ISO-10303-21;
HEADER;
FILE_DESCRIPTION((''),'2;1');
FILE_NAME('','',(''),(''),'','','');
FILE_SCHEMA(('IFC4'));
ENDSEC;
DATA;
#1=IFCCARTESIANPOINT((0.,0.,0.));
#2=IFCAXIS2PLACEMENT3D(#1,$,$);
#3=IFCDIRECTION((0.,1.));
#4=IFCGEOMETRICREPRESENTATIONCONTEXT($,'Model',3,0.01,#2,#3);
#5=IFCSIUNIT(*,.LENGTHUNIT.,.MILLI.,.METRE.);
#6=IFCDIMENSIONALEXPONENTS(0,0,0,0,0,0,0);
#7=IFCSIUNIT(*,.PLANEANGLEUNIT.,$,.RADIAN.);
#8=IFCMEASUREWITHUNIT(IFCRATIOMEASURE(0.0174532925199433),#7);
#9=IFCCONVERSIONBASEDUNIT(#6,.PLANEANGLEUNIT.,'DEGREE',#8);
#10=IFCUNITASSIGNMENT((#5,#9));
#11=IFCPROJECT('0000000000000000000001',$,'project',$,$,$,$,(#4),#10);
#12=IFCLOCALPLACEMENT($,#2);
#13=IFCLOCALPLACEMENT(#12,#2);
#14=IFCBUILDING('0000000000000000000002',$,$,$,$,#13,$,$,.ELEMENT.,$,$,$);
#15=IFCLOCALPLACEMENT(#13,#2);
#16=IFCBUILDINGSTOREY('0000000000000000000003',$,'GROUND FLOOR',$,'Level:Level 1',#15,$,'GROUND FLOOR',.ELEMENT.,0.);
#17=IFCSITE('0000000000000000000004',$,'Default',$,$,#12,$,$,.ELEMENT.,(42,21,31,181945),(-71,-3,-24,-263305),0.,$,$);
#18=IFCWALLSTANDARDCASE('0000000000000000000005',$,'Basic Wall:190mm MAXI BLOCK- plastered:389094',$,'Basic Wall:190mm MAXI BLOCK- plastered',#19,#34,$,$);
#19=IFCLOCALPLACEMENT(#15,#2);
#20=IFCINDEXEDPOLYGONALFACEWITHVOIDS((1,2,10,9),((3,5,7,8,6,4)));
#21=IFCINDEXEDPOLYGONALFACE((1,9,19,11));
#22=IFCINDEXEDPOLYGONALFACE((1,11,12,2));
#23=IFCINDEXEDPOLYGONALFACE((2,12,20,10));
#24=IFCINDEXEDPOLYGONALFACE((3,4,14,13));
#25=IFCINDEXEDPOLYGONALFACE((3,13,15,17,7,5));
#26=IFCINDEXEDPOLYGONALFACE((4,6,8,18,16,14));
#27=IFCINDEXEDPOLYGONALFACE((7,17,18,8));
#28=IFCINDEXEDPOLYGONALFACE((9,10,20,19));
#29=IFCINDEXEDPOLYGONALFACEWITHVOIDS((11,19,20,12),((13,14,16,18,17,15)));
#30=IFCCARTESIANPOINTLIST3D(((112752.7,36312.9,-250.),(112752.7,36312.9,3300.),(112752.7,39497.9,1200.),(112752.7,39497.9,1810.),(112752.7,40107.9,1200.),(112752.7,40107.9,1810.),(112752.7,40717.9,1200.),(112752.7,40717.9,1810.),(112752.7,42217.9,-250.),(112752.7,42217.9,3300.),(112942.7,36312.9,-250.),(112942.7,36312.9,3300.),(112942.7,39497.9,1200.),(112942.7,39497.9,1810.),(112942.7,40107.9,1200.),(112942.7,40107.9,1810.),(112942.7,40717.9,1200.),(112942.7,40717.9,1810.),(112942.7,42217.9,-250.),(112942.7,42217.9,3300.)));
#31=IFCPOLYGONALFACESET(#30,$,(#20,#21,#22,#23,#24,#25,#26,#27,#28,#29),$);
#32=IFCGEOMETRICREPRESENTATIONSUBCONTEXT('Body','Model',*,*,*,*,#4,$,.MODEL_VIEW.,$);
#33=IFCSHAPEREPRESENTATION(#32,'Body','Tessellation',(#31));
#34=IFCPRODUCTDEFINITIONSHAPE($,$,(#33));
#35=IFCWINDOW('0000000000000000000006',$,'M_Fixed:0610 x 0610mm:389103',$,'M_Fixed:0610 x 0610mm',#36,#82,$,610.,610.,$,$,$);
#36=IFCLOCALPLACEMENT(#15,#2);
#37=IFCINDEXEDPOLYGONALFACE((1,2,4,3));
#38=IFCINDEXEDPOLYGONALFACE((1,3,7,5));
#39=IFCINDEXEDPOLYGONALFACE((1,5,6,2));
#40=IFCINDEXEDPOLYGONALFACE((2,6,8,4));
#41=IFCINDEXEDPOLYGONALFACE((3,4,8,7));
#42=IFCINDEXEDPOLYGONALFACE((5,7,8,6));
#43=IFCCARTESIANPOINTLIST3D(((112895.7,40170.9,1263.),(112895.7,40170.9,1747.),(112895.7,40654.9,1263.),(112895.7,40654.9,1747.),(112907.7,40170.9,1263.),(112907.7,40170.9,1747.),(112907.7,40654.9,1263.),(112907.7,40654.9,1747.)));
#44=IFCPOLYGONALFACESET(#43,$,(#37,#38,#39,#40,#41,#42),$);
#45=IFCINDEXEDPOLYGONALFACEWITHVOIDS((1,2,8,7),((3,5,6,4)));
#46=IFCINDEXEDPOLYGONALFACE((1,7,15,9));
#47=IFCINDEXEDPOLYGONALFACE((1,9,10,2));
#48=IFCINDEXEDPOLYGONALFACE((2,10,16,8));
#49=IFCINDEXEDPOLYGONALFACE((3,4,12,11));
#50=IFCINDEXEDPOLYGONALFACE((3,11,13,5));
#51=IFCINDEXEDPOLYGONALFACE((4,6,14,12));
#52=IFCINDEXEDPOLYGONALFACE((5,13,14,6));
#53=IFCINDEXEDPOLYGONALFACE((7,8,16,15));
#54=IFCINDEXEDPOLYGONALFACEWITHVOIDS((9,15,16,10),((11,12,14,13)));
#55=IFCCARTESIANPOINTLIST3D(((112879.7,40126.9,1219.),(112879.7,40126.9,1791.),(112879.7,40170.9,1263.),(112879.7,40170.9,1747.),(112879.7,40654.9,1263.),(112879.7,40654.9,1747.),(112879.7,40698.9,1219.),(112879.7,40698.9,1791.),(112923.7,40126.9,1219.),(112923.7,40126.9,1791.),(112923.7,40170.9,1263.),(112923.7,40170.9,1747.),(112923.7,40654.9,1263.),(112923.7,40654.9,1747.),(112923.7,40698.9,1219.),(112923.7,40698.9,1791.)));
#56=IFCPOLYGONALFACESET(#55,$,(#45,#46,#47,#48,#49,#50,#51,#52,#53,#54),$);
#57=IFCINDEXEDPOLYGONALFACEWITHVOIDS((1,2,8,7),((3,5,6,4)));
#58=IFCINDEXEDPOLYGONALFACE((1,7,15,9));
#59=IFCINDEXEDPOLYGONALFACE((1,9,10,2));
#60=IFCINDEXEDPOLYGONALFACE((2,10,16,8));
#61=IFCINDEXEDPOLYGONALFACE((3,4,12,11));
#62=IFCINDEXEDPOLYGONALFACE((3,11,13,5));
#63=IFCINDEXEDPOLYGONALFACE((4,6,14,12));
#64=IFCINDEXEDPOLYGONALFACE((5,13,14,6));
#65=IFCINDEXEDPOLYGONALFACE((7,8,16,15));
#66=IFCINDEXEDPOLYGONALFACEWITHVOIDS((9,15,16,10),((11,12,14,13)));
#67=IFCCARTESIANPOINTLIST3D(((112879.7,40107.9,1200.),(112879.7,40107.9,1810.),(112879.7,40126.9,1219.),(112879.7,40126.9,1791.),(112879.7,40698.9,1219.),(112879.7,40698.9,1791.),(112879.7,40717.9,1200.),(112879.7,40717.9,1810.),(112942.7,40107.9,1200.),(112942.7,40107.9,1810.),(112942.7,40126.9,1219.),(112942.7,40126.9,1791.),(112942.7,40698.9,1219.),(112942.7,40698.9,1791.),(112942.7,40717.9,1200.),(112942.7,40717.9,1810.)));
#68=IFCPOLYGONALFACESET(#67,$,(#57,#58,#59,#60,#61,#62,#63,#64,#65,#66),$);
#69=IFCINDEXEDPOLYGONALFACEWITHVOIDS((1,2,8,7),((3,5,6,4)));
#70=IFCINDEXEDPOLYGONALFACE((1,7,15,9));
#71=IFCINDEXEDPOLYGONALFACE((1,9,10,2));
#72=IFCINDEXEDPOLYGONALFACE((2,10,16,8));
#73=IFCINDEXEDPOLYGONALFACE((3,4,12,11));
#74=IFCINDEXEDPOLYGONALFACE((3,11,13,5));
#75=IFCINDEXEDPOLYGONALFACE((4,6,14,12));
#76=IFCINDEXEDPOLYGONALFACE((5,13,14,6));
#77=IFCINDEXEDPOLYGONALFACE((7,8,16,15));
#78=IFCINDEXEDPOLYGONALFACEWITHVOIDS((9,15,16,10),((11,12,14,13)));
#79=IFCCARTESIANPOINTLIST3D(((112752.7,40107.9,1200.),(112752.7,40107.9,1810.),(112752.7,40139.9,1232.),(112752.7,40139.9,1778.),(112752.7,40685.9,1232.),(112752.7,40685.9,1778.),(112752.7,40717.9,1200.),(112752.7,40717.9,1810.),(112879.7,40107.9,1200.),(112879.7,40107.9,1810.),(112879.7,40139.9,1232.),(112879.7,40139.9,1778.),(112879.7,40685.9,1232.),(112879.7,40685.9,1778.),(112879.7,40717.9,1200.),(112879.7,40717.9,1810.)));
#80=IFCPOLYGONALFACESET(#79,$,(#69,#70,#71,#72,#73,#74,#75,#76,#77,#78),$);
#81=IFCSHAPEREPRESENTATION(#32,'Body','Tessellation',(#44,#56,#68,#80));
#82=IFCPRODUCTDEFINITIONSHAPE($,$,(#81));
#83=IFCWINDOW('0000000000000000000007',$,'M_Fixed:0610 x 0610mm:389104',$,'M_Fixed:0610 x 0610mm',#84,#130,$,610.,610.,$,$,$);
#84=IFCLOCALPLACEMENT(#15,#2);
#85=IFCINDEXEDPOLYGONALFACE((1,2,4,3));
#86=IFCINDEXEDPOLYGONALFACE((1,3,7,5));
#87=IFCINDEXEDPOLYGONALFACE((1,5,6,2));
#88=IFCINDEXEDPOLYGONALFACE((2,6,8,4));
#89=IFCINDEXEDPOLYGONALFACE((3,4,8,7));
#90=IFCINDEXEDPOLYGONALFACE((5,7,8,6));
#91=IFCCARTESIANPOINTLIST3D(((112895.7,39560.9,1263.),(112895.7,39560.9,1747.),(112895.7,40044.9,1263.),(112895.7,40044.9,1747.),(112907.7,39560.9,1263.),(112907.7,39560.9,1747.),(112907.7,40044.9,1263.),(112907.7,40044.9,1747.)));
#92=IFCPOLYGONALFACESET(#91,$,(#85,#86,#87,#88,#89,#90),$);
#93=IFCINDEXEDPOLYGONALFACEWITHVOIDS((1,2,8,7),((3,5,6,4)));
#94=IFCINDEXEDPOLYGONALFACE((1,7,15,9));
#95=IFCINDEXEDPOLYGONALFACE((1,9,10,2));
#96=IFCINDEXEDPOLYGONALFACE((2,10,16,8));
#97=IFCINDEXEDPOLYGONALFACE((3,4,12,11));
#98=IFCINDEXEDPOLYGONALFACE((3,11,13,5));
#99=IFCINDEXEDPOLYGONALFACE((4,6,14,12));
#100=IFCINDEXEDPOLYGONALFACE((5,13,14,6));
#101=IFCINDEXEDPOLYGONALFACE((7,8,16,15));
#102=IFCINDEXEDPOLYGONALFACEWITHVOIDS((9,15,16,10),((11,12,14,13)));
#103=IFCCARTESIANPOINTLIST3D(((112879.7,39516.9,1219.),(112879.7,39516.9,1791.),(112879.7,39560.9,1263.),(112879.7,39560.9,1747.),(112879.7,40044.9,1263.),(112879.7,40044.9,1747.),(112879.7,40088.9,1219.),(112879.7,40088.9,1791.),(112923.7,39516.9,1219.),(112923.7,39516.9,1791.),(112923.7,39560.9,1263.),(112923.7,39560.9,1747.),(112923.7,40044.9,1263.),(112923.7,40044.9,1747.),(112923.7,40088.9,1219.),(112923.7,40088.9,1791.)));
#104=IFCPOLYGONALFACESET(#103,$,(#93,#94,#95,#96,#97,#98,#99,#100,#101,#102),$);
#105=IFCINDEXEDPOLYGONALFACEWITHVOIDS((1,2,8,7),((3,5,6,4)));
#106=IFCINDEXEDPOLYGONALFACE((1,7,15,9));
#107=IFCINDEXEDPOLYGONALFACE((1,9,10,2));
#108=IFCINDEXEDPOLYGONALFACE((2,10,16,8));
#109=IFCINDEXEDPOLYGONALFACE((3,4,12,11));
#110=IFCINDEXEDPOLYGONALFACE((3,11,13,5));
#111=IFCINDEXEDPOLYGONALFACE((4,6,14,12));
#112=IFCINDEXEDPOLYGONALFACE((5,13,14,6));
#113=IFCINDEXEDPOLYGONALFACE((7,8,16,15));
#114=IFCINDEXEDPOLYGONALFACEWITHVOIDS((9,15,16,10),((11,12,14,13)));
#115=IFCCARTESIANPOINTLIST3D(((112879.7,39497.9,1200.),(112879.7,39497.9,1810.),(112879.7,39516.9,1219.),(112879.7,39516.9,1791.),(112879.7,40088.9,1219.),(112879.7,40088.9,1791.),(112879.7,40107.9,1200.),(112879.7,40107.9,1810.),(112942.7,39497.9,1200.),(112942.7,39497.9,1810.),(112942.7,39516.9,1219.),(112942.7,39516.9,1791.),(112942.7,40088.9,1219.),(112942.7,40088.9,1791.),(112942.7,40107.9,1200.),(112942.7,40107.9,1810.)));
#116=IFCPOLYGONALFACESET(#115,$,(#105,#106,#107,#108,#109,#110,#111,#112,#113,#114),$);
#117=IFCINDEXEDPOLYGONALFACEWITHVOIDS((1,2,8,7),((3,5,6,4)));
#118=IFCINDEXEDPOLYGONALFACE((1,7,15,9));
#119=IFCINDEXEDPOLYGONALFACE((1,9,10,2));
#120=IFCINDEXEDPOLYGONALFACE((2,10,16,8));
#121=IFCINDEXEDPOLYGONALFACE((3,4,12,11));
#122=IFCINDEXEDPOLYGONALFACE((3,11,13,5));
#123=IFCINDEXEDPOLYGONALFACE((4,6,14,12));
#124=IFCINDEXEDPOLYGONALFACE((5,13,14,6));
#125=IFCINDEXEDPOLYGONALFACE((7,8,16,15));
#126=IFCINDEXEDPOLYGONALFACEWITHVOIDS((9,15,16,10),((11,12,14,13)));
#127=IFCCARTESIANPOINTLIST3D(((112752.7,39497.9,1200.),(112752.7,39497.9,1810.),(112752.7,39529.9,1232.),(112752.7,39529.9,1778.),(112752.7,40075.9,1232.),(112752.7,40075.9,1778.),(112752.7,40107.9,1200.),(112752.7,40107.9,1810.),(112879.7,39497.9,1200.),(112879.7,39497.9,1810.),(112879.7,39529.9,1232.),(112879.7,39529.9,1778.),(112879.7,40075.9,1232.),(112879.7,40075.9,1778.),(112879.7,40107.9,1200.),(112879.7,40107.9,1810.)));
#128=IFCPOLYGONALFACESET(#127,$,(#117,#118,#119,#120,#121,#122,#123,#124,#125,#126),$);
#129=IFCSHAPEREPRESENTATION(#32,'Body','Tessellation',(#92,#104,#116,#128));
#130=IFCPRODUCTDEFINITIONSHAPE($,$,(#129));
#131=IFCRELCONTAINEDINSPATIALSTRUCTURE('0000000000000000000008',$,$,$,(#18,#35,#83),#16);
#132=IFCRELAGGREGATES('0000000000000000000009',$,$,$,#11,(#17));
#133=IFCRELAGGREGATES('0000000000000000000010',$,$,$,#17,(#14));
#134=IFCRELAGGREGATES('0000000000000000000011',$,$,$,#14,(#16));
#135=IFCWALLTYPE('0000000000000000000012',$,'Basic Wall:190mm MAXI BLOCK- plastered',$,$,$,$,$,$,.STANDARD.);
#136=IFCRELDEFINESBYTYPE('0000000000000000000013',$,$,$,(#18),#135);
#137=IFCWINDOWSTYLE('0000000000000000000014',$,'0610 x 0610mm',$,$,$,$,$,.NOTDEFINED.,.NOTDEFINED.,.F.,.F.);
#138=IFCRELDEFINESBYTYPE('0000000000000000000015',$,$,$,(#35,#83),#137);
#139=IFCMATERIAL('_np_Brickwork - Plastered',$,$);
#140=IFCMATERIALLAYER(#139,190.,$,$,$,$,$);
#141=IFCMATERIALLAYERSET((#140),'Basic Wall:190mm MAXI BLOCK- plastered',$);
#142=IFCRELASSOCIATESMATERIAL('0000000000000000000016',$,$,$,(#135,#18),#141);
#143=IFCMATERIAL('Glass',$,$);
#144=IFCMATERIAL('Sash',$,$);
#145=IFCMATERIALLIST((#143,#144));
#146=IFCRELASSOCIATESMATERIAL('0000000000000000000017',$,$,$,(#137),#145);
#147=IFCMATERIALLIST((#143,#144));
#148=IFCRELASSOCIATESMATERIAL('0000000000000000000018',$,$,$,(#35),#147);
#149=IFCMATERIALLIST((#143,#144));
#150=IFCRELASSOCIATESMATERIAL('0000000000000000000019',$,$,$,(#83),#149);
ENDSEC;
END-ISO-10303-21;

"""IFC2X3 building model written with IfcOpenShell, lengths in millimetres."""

from ifc_helpers import new_model, entity, si_unit, converted_unit, direction, frame, frame_2d, origin, place, context, subcontext, project, spatial, polyline, rectangle, outline, extrude, source, transform, mapped, material, material_list, layer, layer_set, layer_usage, type_object, type_shapes, element, fill, save


model = new_model("IFC2X3")

# Units and contexts
model_context = context("Model", 3, precision=0.01, world=origin(), true_north=direction((0.0, 1.0)))
body_context = subcontext(model_context, "Body", "Model", "MODEL_VIEW")
ifc_project = project(units=[si_unit("LENGTHUNIT", "METRE", prefix="MILLI"), converted_unit("PLANEANGLEUNIT", "DEGREE", entity("IfcRatioMeasure", 0.0174532925199433), si_unit("PLANEANGLEUNIT", "RADIAN"), dimensions=[0, 0, 0, 0, 0, 0, 0])], contexts=[model_context])

# Site, building, storey
site_placement = place(None, origin())
site = spatial("IfcSite", under=ifc_project, at=site_placement, Name="Default", CompositionType="ELEMENT", RefLatitude=(42, 21, 31, 181945), RefLongitude=(-71, -3, -24, -263305), RefElevation=0.0)
building_placement = place(site_placement, origin())
building = spatial("IfcBuilding", under=site, at=building_placement, CompositionType="ELEMENT")
storey_placement = place(building_placement, origin())
storey = spatial("IfcBuildingStorey", under=building, at=storey_placement, Name="GROUND FLOOR", ObjectType="Level:Level 1", LongName="GROUND FLOOR", CompositionType="ELEMENT", Elevation=0.0)

# Wall, openings, windows
ifc_material_1 = material(Name="_np_Brickwork - Plastered")
ifc_layer = layer(ifc_material_1, 190.0)
ifc_layer_set = layer_set([ifc_layer], Name="Basic Wall:190mm MAXI BLOCK- plastered")
ifc_layer_usage_1 = layer_usage(ifc_layer_set, "AXIS2", "NEGATIVE", 95.0)
wall_type = type_object("IfcWallType", Name="Basic Wall:190mm MAXI BLOCK- plastered", PredefinedType="STANDARD", material=ifc_layer_set)
wall_1_placement = place(storey_placement, frame((112847.7, 36312.9, -250.0), z_axis=(0.0, 0.0, 1.0), x_axis=(0.0, 1.0, 0.0)))
wall_1 = element("IfcWallStandardCase", 1, at=wall_1_placement, inside=storey, type_object=wall_type, material=ifc_layer_usage_1, Name="Basic Wall:190mm MAXI BLOCK- plastered:389094", ObjectType="Basic Wall:190mm MAXI BLOCK- plastered", context=body_context, shape_type="SweptSolid", body=[
    extrude(rectangle(XDim=5905.0, YDim=190.0, at=frame_2d((2952.5, 0.0), x_axis=(-1.0, 0.0))), origin(), (0.0, 0.0, 1.0), 3550.0),
])
opening_1_placement = place(wall_1_placement, frame((4405.0, 95.0, 1450.0)))
opening_1 = element("IfcOpeningElement", 2, at=opening_1_placement, cuts=wall_1, ObjectType="Opening", context=body_context, shape_type="SweptSolid", body=[
    extrude(rectangle(XDim=610.0, YDim=610.0, at=frame_2d((305.0, 305.0), x_axis=(1.0, 0.0))), frame((0.0, 0.0, 0.0), z_axis=(0.0, -1.0, 0.0), x_axis=(0.0, 0.0, 1.0)), (0.0, 0.0, 1.0), 190.0),
])
opening_2_placement = place(wall_1_placement, frame((3795.0, 95.0, 1450.0)))
opening_2 = element("IfcOpeningElement", 3, at=opening_2_placement, cuts=wall_1, ObjectType="Opening", context=body_context, shape_type="SweptSolid", body=[
    extrude(rectangle(XDim=610.0, YDim=610.0, at=frame_2d((305.0, 305.0), x_axis=(1.0, 0.0))), frame((0.0, 0.0, 0.0), z_axis=(0.0, -1.0, 0.0), x_axis=(0.0, 0.0, 1.0)), (0.0, 0.0, 1.0), 190.0),
])
ifc_material_2 = material(Name="Glass")
ifc_material_3 = material(Name="Sash")
ifc_material_list_1 = material_list([ifc_material_2, ifc_material_3])
ifc_material_list_2 = material_list([ifc_material_2, ifc_material_3])
window_style = type_object("IfcWindowStyle", Name="0610 x 0610mm", ConstructionType="NOTDEFINED", OperationType="NOTDEFINED", ParameterTakesPrecedence=False, Sizeable=False, material=ifc_material_list_2)
shared_shape_1 = source(origin(), body_context, "Body", "SweptSolid", [
    extrude(rectangle(XDim=12.0, YDim=484.0, at=frame_2d((0.0, 0.0), x_axis=(1.0, 0.0))), frame((305.0, 149.0, 63.0), z_axis=(0.0, 0.0, 1.0), x_axis=(0.0, -1.0, 0.0)), (0.0, 0.0, 1.0), 484.0),
    extrude(outline(polyline([(-286.0, -286.0), (286.0, -286.0), (286.0, 286.0), (-286.0, 286.0), (-286.0, -286.0)]), holes=[polyline([(-242.0, -242.0), (-242.0, 242.0), (242.0, 242.0), (242.0, -242.0), (-242.0, -242.0)])]), frame((305.0, 127.0, 305.0), z_axis=(0.0, 1.0, 0.0), x_axis=(1.0, 0.0, 0.0)), (0.0, 0.0, 1.0), 44.0),
    extrude(outline(polyline([(-305.0, -305.0), (305.0, -305.0), (305.0, 305.0), (-305.0, 305.0), (-305.0, -305.0)]), holes=[polyline([(-286.0, -286.0), (-286.0, 286.0), (286.0, 286.0), (286.0, -286.0), (-286.0, -286.0)])]), frame((305.0, 127.0, 305.0), z_axis=(0.0, 1.0, 0.0), x_axis=(1.0, 0.0, 0.0)), (0.0, 0.0, 1.0), 63.0),
    extrude(outline(polyline([(-305.0, -305.0), (305.0, -305.0), (305.0, 305.0), (-305.0, 305.0), (-305.0, -305.0)]), holes=[polyline([(-273.0, -273.0), (-273.0, 273.0), (273.0, 273.0), (273.0, -273.0), (-273.0, -273.0)])]), frame((305.0, 0.0, 305.0), z_axis=(0.0, 1.0, 0.0), x_axis=(1.0, 0.0, 0.0)), (0.0, 0.0, 1.0), 127.0),
])
type_shapes(window_style, [shared_shape_1])
window_1_placement = place(opening_1_placement, frame((0.0, 0.0, 0.0), z_axis=(0.0, 0.0, 1.0), x_axis=(-1.0, 0.0, 0.0)))
window_1 = element("IfcWindow", 4, at=window_1_placement, inside=storey, type_object=window_style, material=ifc_material_list_1, Name="M_Fixed:0610 x 0610mm:389103", ObjectType="M_Fixed:0610 x 0610mm", OverallHeight=610.0, OverallWidth=610.0, context=body_context, shape_type="MappedRepresentation", body=[
    mapped(shared_shape_1, transform((0.0, 0.0, 0.0), scale=1.0)),
])
fill(opening_1, window_1)
ifc_material_list_3 = material_list([ifc_material_2, ifc_material_3])
window_2_placement = place(opening_2_placement, frame((0.0, 0.0, 0.0), z_axis=(0.0, 0.0, 1.0), x_axis=(-1.0, 0.0, 0.0)))
window_2 = element("IfcWindow", 5, at=window_2_placement, inside=storey, type_object=window_style, material=ifc_material_list_3, Name="M_Fixed:0610 x 0610mm:389104", ObjectType="M_Fixed:0610 x 0610mm", OverallHeight=610.0, OverallWidth=610.0, context=body_context, shape_type="MappedRepresentation", body=[
    mapped(shared_shape_1, transform((0.0, 0.0, 0.0), scale=1.0)),
])
fill(opening_2, window_2)

save(model, "model.ifc")
